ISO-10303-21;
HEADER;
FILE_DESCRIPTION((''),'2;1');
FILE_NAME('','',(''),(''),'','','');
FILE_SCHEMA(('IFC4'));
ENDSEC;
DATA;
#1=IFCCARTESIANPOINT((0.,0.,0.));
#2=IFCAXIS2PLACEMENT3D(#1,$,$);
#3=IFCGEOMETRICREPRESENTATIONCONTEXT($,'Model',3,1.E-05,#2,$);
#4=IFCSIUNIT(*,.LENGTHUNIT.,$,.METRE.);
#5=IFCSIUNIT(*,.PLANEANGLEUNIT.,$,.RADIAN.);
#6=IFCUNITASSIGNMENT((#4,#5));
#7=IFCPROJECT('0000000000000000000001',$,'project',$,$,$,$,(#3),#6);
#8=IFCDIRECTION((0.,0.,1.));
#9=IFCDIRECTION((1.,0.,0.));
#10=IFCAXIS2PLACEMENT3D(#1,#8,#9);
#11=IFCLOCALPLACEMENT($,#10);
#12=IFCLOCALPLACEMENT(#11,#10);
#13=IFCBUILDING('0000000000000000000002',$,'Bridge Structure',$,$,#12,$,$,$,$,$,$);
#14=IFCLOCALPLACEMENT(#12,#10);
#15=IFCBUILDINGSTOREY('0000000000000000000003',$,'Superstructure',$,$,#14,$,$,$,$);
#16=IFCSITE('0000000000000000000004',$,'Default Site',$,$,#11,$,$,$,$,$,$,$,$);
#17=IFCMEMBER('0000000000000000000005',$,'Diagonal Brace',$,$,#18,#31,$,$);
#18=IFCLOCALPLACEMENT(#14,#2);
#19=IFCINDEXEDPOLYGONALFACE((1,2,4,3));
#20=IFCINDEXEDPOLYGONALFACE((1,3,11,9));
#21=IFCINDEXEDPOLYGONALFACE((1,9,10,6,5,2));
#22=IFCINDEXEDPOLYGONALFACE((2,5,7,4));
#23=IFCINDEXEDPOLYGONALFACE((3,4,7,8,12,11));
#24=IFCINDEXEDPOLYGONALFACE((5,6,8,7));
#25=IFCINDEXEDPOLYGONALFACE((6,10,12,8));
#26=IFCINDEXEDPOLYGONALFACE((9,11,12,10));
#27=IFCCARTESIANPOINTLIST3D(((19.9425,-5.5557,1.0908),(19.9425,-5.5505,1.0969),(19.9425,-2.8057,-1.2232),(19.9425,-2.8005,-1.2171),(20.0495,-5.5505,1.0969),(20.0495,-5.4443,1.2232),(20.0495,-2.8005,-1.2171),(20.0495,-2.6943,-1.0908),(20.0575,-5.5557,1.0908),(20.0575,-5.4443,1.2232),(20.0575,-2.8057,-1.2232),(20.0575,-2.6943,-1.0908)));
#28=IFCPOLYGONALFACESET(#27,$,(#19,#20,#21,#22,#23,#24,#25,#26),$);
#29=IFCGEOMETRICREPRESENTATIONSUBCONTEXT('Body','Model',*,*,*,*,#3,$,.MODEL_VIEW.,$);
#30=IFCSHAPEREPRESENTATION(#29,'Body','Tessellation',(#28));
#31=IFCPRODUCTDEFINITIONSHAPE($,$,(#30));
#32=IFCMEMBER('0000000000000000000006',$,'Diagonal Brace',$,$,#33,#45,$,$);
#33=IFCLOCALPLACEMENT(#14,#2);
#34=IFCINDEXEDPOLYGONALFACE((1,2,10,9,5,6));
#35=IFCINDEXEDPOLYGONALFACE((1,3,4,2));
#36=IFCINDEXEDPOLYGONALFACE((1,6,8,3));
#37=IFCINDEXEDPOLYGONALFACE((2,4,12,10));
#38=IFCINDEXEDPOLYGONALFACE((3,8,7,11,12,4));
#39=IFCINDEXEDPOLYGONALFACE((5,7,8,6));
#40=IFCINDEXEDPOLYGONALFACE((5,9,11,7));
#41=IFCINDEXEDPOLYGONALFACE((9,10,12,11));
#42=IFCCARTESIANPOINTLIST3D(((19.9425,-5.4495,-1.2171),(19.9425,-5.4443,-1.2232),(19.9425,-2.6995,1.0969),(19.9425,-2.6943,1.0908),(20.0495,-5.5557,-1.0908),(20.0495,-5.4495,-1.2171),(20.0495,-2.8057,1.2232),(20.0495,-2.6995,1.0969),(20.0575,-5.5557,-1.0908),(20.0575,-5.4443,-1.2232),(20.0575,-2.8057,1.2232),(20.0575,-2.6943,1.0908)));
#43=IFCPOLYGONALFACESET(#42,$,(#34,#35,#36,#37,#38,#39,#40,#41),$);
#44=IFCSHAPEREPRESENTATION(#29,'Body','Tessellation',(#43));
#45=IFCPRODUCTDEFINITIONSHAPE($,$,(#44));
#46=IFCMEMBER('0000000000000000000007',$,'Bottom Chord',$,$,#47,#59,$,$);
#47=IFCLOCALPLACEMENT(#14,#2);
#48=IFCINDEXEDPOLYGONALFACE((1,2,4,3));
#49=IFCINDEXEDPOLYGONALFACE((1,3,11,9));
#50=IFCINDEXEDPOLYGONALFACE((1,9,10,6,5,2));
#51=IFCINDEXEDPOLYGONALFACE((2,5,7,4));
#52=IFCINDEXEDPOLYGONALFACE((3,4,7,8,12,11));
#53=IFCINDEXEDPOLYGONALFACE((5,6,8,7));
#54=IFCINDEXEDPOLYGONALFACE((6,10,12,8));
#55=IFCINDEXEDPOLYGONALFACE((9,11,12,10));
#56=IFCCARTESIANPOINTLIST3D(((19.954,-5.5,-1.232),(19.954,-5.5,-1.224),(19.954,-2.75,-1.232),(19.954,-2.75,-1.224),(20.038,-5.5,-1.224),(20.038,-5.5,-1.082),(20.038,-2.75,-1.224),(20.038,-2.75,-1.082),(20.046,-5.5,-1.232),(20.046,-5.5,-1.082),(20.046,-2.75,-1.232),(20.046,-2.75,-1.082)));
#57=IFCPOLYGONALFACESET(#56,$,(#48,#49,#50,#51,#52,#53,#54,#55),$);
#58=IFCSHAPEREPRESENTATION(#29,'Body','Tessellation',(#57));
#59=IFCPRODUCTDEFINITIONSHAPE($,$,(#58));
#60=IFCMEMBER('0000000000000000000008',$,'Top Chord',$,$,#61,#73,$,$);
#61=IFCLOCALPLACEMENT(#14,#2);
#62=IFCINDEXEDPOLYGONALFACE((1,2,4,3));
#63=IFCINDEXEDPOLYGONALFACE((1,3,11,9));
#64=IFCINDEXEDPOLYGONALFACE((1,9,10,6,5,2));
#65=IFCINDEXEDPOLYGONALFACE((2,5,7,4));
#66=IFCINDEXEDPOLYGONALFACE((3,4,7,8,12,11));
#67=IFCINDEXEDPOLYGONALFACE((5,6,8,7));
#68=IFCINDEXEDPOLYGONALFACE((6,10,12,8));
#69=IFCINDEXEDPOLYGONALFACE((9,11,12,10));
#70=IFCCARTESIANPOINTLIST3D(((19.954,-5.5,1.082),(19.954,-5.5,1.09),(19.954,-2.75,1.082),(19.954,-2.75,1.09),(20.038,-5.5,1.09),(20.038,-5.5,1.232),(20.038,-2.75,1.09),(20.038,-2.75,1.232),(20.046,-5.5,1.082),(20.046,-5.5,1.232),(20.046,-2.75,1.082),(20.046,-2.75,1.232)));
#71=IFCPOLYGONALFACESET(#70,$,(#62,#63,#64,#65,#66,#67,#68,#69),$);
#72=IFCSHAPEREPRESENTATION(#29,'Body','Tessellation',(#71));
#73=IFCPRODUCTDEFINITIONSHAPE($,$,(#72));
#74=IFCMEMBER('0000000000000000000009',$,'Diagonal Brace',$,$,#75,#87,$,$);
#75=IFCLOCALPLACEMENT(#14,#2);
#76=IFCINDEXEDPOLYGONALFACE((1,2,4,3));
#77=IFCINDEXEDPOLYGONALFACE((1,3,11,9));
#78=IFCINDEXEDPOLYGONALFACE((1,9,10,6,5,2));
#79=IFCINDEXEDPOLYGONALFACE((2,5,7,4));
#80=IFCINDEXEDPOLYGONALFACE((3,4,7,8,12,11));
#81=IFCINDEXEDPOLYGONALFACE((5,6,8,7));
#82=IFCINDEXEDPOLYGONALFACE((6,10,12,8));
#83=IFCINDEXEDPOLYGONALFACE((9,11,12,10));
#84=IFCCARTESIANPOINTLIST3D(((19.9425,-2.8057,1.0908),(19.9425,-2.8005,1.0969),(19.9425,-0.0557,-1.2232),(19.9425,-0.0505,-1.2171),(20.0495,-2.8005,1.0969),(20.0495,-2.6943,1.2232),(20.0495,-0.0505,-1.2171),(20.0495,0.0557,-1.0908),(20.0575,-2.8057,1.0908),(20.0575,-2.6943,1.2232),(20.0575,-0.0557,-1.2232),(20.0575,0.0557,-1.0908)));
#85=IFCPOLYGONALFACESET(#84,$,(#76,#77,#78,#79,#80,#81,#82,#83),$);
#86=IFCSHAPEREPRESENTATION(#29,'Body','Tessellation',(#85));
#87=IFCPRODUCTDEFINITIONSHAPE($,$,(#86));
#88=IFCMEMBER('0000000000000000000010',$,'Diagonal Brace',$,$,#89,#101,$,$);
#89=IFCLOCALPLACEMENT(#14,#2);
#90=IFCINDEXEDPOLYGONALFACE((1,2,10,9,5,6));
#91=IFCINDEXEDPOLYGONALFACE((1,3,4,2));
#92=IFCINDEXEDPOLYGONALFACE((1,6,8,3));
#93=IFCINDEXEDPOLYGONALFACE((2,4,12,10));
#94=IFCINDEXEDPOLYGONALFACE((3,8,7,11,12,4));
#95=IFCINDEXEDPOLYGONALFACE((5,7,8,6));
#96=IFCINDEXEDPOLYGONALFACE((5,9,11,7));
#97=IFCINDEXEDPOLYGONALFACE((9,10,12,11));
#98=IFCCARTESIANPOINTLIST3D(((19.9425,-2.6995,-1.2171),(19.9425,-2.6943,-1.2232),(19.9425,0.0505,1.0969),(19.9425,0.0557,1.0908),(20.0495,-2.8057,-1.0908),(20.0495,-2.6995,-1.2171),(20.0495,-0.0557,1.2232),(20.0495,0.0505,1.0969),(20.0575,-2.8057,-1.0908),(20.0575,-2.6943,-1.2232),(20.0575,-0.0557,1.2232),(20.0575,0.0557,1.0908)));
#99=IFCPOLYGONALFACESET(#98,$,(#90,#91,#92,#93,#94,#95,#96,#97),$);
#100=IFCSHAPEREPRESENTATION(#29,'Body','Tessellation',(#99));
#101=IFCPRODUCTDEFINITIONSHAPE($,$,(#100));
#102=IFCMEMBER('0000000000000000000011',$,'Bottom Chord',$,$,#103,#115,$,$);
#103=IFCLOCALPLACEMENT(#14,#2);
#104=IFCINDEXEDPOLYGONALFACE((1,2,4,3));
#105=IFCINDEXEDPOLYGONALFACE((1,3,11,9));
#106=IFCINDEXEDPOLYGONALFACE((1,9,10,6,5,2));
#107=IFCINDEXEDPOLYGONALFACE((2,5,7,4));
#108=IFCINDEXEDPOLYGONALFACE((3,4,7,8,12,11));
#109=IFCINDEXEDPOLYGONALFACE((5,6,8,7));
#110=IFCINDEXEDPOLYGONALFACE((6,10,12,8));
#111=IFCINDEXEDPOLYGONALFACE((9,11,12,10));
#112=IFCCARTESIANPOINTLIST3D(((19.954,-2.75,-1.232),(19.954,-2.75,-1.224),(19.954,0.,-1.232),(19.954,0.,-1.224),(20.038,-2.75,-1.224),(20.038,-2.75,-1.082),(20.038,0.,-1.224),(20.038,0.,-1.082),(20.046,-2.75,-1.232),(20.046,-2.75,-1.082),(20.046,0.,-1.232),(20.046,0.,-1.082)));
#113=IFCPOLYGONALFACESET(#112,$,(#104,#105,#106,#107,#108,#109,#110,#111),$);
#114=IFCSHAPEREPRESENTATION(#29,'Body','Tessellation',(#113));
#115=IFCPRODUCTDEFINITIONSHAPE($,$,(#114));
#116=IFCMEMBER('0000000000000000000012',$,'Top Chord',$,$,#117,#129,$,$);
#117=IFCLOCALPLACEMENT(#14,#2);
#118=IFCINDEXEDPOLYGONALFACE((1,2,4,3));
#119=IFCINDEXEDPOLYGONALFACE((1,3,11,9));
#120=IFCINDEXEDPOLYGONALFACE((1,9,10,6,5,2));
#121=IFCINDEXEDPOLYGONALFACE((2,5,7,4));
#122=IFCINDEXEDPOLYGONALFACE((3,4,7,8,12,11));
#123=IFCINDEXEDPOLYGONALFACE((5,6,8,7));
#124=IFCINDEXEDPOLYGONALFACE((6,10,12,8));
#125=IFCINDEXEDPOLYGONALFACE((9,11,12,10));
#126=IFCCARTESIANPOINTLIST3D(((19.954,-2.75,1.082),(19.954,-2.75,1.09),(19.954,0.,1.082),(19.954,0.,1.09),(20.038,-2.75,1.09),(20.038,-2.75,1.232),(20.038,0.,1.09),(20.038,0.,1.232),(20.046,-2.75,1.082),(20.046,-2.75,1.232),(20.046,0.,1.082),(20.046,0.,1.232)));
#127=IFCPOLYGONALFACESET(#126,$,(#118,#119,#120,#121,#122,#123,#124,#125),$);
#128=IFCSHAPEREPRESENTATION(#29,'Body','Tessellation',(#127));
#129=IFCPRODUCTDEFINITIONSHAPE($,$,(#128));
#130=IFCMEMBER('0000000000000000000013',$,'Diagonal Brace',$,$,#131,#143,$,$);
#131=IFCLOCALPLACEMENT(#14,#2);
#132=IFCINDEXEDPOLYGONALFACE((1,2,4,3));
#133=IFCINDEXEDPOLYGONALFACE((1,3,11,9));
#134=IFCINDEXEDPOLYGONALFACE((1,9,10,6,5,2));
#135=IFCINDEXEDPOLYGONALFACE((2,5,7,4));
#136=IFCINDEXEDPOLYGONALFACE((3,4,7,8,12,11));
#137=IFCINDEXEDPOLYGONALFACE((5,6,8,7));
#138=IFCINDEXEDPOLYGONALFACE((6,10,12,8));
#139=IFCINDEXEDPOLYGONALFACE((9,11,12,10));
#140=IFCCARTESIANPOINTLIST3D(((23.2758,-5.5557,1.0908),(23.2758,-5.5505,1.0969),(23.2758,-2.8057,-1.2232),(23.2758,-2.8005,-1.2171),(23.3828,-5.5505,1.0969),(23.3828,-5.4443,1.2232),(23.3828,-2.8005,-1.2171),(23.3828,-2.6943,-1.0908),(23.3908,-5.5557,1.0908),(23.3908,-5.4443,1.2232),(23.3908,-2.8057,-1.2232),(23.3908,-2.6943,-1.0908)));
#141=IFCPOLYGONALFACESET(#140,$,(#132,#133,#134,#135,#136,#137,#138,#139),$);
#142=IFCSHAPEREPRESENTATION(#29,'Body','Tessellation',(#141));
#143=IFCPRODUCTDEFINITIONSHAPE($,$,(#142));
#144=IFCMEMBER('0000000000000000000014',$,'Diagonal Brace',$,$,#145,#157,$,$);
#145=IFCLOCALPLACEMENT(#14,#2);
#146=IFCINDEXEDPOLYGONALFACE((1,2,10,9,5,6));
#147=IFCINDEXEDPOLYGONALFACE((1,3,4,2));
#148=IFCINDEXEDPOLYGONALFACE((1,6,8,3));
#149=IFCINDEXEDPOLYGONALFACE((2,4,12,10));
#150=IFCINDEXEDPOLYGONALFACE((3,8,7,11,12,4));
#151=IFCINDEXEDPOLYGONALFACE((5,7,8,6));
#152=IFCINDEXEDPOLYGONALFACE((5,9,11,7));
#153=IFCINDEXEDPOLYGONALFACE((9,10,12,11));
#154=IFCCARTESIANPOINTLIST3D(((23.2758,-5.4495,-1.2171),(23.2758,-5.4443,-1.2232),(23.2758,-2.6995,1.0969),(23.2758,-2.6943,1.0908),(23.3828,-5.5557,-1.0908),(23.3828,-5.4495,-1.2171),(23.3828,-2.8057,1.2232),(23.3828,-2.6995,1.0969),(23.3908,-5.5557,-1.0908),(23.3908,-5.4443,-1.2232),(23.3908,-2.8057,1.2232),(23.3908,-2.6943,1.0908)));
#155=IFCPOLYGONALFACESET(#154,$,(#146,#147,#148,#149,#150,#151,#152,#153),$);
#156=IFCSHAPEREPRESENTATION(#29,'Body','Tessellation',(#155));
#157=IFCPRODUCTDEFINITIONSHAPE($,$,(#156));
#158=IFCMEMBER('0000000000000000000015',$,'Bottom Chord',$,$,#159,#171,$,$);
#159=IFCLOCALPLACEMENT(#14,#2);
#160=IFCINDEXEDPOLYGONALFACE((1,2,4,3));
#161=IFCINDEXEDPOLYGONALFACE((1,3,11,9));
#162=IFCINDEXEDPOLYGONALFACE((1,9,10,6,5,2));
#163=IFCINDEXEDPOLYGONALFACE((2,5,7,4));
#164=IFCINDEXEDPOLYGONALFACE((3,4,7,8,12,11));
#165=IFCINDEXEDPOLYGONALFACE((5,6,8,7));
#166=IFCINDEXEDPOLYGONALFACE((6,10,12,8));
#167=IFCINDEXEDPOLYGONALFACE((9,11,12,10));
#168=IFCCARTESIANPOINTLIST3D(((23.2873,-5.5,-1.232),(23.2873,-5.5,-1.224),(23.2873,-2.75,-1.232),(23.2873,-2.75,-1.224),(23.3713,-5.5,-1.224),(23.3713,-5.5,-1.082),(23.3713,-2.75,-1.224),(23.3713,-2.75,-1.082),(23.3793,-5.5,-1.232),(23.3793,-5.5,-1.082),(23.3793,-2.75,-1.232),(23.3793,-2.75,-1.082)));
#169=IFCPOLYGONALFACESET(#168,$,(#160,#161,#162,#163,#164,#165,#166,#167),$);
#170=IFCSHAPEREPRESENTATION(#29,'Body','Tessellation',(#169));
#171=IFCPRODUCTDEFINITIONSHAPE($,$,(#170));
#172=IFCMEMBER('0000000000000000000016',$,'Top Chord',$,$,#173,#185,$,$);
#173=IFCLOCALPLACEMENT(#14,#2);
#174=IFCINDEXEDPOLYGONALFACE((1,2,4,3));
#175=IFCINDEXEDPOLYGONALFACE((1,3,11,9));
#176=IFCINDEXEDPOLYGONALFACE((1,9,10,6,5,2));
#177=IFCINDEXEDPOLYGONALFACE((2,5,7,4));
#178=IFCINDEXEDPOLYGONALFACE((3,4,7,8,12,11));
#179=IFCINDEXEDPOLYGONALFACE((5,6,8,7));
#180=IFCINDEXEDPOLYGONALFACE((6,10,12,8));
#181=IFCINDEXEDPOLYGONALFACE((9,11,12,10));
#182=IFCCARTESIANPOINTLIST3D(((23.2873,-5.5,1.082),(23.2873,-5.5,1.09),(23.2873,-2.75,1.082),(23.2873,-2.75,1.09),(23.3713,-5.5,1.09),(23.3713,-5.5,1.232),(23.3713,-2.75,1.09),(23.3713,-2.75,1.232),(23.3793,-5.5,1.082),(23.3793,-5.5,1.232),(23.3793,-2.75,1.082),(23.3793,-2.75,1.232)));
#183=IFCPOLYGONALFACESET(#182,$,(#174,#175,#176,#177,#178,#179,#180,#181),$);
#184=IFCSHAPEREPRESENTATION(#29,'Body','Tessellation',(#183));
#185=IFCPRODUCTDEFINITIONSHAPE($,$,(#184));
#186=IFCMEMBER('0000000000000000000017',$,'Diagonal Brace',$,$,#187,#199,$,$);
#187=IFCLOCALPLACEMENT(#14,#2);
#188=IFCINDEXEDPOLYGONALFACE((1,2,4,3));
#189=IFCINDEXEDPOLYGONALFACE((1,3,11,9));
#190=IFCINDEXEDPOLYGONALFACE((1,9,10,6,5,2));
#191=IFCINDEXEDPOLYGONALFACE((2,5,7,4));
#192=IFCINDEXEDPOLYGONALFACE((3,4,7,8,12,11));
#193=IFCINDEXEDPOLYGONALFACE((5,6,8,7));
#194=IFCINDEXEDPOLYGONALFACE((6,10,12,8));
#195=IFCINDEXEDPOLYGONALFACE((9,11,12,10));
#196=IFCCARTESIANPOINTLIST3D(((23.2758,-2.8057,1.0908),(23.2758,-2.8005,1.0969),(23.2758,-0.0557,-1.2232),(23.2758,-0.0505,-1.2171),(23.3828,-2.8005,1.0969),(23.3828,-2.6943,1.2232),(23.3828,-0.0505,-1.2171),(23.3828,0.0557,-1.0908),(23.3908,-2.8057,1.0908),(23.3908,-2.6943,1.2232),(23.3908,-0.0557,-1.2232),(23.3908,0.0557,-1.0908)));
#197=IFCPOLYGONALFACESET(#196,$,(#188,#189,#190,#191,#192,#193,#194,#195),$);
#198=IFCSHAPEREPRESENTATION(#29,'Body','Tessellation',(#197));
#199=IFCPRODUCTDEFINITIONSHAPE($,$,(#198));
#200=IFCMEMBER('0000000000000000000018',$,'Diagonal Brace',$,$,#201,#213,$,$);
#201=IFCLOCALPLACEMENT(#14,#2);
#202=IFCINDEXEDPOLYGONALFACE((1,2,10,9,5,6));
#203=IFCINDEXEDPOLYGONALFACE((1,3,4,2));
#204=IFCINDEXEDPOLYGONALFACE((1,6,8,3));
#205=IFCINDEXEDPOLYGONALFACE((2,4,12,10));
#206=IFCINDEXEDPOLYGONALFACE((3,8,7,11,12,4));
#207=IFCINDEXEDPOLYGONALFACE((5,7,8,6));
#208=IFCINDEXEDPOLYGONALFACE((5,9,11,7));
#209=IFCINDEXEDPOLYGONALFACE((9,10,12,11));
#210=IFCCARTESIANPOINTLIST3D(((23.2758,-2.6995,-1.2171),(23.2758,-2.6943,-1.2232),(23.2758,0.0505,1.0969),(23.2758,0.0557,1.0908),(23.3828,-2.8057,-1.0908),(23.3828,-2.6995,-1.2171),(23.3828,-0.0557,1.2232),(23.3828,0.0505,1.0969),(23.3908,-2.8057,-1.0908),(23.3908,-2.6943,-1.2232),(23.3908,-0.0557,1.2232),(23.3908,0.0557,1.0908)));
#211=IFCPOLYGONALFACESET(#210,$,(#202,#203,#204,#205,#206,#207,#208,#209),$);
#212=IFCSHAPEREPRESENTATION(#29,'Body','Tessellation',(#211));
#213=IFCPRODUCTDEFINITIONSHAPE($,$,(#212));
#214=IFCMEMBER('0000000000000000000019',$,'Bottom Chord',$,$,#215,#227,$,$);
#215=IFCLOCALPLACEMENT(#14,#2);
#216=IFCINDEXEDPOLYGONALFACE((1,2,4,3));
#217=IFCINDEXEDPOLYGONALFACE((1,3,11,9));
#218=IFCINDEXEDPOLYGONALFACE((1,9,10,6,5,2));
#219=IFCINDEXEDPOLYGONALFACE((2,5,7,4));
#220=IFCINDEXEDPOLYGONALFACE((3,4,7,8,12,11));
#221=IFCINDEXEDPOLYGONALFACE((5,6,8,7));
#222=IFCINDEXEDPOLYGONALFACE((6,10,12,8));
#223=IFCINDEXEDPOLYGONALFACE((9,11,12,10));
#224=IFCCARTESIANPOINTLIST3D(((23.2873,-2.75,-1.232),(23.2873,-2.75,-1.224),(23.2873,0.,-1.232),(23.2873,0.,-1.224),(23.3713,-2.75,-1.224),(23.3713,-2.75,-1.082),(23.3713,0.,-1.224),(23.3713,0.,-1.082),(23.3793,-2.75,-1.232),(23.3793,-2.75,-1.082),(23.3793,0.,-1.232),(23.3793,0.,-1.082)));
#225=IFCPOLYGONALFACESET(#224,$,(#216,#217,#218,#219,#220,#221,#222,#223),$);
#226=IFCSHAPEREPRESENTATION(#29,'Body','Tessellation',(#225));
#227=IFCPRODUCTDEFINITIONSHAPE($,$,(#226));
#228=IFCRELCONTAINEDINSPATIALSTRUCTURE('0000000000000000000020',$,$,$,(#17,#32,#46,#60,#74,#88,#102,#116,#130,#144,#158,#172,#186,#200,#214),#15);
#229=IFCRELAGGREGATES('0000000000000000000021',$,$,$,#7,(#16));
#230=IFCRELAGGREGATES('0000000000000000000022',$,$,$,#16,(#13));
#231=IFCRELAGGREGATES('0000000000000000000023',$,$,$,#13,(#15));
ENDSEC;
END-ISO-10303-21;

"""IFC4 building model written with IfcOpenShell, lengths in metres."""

from ifc_helpers import new_model, si_unit, frame, origin, origin_with_axes, origin_2d_with_axis, place, context, subcontext, project, spatial, l_section, extrude, element, save


model = new_model("IFC4")

# Units and contexts
model_context = context("Model", 3, precision=1e-05, world=origin())
body_context = subcontext(model_context, "Body", "Model", "MODEL_VIEW")
ifc_project = project(units=[si_unit("LENGTHUNIT", "METRE"), si_unit("PLANEANGLEUNIT", "RADIAN")], contexts=[model_context])

# Site, building, storey
site_placement = place(None, origin_with_axes())
site = spatial("IfcSite", under=ifc_project, at=site_placement, Name="Default Site")
building_placement = place(site_placement, origin_with_axes())
building = spatial("IfcBuilding", under=site, at=building_placement, Name="Bridge Structure")
storey_placement = place(building_placement, origin_with_axes())
storey = spatial("IfcBuildingStorey", under=building, at=storey_placement, Name="Superstructure")

# Members
for number, where, z_axis, x_axis, name in (
    (1, (20.0, -5.5, 1.157), (0.0, 0.765156, -0.643844), (-1.0, 0.0, 0.0), "Diagonal Brace"),
    (2, (20.0, -5.5, -1.157), (0.0, 0.765156, 0.643844), (-1.0, 0.0, 0.0), "Diagonal Brace"),
):
    element("IfcMember", number, at=place(storey_placement, frame(where, z_axis=z_axis, x_axis=x_axis)), inside=storey, Name=name, context=body_context, shape_type="SweptSolid", body=[
        extrude(l_section(Depth=0.173, Width=0.115, Thickness=0.008, at=origin_2d_with_axis()), origin_with_axes(), (0.0, 0.0, 1.0), 3.594),
    ])
for number, where, z_axis, x_axis, name in (
    (3, (20.0, -5.5, -1.157), (0.0, 1.0, 0.0), (-1.0, 0.0, 0.0), "Bottom Chord"),
    (4, (20.0, -5.5, 1.157), (0.0, 1.0, 0.0), (-1.0, 0.0, 0.0), "Top Chord"),
):
    element("IfcMember", number, at=place(storey_placement, frame(where, z_axis=z_axis, x_axis=x_axis)), inside=storey, Name=name, context=body_context, shape_type="SweptSolid", body=[
        extrude(l_section(Depth=0.15, Width=0.092, Thickness=0.008, at=origin_2d_with_axis()), origin_with_axes(), (0.0, 0.0, 1.0), 2.75),
    ])
for number, where, z_axis, x_axis, name in (
    (5, (20.0, -2.75, 1.157), (0.0, 0.765156, -0.643844), (-1.0, 0.0, 0.0), "Diagonal Brace"),
    (6, (20.0, -2.75, -1.157), (0.0, 0.765156, 0.643844), (-1.0, 0.0, 0.0), "Diagonal Brace"),
):
    element("IfcMember", number, at=place(storey_placement, frame(where, z_axis=z_axis, x_axis=x_axis)), inside=storey, Name=name, context=body_context, shape_type="SweptSolid", body=[
        extrude(l_section(Depth=0.173, Width=0.115, Thickness=0.008, at=origin_2d_with_axis()), origin_with_axes(), (0.0, 0.0, 1.0), 3.594),
    ])
for number, where, z_axis, x_axis, name in (
    (7, (20.0, -2.75, -1.157), (0.0, 1.0, 0.0), (-1.0, 0.0, 0.0), "Bottom Chord"),
    (8, (20.0, -2.75, 1.157), (0.0, 1.0, 0.0), (-1.0, 0.0, 0.0), "Top Chord"),
):
    element("IfcMember", number, at=place(storey_placement, frame(where, z_axis=z_axis, x_axis=x_axis)), inside=storey, Name=name, context=body_context, shape_type="SweptSolid", body=[
        extrude(l_section(Depth=0.15, Width=0.092, Thickness=0.008, at=origin_2d_with_axis()), origin_with_axes(), (0.0, 0.0, 1.0), 2.75),
    ])
for number, where, z_axis, x_axis, name in (
    (9, (23.3333, -5.5, 1.157), (0.0, 0.765156, -0.643844), (-1.0, 0.0, 0.0), "Diagonal Brace"),
    (10, (23.3333, -5.5, -1.157), (0.0, 0.765156, 0.643844), (-1.0, 0.0, 0.0), "Diagonal Brace"),
):
    element("IfcMember", number, at=place(storey_placement, frame(where, z_axis=z_axis, x_axis=x_axis)), inside=storey, Name=name, context=body_context, shape_type="SweptSolid", body=[
        extrude(l_section(Depth=0.173, Width=0.115, Thickness=0.008, at=origin_2d_with_axis()), origin_with_axes(), (0.0, 0.0, 1.0), 3.594),
    ])
for number, where, z_axis, x_axis, name in (
    (11, (23.3333, -5.5, -1.157), (0.0, 1.0, 0.0), (-1.0, 0.0, 0.0), "Bottom Chord"),
    (12, (23.3333, -5.5, 1.157), (0.0, 1.0, 0.0), (-1.0, 0.0, 0.0), "Top Chord"),
):
    element("IfcMember", number, at=place(storey_placement, frame(where, z_axis=z_axis, x_axis=x_axis)), inside=storey, Name=name, context=body_context, shape_type="SweptSolid", body=[
        extrude(l_section(Depth=0.15, Width=0.092, Thickness=0.008, at=origin_2d_with_axis()), origin_with_axes(), (0.0, 0.0, 1.0), 2.75),
    ])
for number, where, z_axis, x_axis, name in (
    (13, (23.3333, -2.75, 1.157), (0.0, 0.765156, -0.643844), (-1.0, 0.0, 0.0), "Diagonal Brace"),
    (14, (23.3333, -2.75, -1.157), (0.0, 0.765156, 0.643844), (-1.0, 0.0, 0.0), "Diagonal Brace"),
):
    element("IfcMember", number, at=place(storey_placement, frame(where, z_axis=z_axis, x_axis=x_axis)), inside=storey, Name=name, context=body_context, shape_type="SweptSolid", body=[
        extrude(l_section(Depth=0.173, Width=0.115, Thickness=0.008, at=origin_2d_with_axis()), origin_with_axes(), (0.0, 0.0, 1.0), 3.594),
    ])
member_placement = place(storey_placement, frame((23.3333, -2.75, -1.157), z_axis=(0.0, 1.0, 0.0), x_axis=(-1.0, 0.0, 0.0)))
element("IfcMember", 15, at=member_placement, inside=storey, Name="Bottom Chord", context=body_context, shape_type="SweptSolid", body=[
    extrude(l_section(Depth=0.15, Width=0.092, Thickness=0.008, at=origin_2d_with_axis()), origin_with_axes(), (0.0, 0.0, 1.0), 2.75),
])

save(model, "model.ifc")
